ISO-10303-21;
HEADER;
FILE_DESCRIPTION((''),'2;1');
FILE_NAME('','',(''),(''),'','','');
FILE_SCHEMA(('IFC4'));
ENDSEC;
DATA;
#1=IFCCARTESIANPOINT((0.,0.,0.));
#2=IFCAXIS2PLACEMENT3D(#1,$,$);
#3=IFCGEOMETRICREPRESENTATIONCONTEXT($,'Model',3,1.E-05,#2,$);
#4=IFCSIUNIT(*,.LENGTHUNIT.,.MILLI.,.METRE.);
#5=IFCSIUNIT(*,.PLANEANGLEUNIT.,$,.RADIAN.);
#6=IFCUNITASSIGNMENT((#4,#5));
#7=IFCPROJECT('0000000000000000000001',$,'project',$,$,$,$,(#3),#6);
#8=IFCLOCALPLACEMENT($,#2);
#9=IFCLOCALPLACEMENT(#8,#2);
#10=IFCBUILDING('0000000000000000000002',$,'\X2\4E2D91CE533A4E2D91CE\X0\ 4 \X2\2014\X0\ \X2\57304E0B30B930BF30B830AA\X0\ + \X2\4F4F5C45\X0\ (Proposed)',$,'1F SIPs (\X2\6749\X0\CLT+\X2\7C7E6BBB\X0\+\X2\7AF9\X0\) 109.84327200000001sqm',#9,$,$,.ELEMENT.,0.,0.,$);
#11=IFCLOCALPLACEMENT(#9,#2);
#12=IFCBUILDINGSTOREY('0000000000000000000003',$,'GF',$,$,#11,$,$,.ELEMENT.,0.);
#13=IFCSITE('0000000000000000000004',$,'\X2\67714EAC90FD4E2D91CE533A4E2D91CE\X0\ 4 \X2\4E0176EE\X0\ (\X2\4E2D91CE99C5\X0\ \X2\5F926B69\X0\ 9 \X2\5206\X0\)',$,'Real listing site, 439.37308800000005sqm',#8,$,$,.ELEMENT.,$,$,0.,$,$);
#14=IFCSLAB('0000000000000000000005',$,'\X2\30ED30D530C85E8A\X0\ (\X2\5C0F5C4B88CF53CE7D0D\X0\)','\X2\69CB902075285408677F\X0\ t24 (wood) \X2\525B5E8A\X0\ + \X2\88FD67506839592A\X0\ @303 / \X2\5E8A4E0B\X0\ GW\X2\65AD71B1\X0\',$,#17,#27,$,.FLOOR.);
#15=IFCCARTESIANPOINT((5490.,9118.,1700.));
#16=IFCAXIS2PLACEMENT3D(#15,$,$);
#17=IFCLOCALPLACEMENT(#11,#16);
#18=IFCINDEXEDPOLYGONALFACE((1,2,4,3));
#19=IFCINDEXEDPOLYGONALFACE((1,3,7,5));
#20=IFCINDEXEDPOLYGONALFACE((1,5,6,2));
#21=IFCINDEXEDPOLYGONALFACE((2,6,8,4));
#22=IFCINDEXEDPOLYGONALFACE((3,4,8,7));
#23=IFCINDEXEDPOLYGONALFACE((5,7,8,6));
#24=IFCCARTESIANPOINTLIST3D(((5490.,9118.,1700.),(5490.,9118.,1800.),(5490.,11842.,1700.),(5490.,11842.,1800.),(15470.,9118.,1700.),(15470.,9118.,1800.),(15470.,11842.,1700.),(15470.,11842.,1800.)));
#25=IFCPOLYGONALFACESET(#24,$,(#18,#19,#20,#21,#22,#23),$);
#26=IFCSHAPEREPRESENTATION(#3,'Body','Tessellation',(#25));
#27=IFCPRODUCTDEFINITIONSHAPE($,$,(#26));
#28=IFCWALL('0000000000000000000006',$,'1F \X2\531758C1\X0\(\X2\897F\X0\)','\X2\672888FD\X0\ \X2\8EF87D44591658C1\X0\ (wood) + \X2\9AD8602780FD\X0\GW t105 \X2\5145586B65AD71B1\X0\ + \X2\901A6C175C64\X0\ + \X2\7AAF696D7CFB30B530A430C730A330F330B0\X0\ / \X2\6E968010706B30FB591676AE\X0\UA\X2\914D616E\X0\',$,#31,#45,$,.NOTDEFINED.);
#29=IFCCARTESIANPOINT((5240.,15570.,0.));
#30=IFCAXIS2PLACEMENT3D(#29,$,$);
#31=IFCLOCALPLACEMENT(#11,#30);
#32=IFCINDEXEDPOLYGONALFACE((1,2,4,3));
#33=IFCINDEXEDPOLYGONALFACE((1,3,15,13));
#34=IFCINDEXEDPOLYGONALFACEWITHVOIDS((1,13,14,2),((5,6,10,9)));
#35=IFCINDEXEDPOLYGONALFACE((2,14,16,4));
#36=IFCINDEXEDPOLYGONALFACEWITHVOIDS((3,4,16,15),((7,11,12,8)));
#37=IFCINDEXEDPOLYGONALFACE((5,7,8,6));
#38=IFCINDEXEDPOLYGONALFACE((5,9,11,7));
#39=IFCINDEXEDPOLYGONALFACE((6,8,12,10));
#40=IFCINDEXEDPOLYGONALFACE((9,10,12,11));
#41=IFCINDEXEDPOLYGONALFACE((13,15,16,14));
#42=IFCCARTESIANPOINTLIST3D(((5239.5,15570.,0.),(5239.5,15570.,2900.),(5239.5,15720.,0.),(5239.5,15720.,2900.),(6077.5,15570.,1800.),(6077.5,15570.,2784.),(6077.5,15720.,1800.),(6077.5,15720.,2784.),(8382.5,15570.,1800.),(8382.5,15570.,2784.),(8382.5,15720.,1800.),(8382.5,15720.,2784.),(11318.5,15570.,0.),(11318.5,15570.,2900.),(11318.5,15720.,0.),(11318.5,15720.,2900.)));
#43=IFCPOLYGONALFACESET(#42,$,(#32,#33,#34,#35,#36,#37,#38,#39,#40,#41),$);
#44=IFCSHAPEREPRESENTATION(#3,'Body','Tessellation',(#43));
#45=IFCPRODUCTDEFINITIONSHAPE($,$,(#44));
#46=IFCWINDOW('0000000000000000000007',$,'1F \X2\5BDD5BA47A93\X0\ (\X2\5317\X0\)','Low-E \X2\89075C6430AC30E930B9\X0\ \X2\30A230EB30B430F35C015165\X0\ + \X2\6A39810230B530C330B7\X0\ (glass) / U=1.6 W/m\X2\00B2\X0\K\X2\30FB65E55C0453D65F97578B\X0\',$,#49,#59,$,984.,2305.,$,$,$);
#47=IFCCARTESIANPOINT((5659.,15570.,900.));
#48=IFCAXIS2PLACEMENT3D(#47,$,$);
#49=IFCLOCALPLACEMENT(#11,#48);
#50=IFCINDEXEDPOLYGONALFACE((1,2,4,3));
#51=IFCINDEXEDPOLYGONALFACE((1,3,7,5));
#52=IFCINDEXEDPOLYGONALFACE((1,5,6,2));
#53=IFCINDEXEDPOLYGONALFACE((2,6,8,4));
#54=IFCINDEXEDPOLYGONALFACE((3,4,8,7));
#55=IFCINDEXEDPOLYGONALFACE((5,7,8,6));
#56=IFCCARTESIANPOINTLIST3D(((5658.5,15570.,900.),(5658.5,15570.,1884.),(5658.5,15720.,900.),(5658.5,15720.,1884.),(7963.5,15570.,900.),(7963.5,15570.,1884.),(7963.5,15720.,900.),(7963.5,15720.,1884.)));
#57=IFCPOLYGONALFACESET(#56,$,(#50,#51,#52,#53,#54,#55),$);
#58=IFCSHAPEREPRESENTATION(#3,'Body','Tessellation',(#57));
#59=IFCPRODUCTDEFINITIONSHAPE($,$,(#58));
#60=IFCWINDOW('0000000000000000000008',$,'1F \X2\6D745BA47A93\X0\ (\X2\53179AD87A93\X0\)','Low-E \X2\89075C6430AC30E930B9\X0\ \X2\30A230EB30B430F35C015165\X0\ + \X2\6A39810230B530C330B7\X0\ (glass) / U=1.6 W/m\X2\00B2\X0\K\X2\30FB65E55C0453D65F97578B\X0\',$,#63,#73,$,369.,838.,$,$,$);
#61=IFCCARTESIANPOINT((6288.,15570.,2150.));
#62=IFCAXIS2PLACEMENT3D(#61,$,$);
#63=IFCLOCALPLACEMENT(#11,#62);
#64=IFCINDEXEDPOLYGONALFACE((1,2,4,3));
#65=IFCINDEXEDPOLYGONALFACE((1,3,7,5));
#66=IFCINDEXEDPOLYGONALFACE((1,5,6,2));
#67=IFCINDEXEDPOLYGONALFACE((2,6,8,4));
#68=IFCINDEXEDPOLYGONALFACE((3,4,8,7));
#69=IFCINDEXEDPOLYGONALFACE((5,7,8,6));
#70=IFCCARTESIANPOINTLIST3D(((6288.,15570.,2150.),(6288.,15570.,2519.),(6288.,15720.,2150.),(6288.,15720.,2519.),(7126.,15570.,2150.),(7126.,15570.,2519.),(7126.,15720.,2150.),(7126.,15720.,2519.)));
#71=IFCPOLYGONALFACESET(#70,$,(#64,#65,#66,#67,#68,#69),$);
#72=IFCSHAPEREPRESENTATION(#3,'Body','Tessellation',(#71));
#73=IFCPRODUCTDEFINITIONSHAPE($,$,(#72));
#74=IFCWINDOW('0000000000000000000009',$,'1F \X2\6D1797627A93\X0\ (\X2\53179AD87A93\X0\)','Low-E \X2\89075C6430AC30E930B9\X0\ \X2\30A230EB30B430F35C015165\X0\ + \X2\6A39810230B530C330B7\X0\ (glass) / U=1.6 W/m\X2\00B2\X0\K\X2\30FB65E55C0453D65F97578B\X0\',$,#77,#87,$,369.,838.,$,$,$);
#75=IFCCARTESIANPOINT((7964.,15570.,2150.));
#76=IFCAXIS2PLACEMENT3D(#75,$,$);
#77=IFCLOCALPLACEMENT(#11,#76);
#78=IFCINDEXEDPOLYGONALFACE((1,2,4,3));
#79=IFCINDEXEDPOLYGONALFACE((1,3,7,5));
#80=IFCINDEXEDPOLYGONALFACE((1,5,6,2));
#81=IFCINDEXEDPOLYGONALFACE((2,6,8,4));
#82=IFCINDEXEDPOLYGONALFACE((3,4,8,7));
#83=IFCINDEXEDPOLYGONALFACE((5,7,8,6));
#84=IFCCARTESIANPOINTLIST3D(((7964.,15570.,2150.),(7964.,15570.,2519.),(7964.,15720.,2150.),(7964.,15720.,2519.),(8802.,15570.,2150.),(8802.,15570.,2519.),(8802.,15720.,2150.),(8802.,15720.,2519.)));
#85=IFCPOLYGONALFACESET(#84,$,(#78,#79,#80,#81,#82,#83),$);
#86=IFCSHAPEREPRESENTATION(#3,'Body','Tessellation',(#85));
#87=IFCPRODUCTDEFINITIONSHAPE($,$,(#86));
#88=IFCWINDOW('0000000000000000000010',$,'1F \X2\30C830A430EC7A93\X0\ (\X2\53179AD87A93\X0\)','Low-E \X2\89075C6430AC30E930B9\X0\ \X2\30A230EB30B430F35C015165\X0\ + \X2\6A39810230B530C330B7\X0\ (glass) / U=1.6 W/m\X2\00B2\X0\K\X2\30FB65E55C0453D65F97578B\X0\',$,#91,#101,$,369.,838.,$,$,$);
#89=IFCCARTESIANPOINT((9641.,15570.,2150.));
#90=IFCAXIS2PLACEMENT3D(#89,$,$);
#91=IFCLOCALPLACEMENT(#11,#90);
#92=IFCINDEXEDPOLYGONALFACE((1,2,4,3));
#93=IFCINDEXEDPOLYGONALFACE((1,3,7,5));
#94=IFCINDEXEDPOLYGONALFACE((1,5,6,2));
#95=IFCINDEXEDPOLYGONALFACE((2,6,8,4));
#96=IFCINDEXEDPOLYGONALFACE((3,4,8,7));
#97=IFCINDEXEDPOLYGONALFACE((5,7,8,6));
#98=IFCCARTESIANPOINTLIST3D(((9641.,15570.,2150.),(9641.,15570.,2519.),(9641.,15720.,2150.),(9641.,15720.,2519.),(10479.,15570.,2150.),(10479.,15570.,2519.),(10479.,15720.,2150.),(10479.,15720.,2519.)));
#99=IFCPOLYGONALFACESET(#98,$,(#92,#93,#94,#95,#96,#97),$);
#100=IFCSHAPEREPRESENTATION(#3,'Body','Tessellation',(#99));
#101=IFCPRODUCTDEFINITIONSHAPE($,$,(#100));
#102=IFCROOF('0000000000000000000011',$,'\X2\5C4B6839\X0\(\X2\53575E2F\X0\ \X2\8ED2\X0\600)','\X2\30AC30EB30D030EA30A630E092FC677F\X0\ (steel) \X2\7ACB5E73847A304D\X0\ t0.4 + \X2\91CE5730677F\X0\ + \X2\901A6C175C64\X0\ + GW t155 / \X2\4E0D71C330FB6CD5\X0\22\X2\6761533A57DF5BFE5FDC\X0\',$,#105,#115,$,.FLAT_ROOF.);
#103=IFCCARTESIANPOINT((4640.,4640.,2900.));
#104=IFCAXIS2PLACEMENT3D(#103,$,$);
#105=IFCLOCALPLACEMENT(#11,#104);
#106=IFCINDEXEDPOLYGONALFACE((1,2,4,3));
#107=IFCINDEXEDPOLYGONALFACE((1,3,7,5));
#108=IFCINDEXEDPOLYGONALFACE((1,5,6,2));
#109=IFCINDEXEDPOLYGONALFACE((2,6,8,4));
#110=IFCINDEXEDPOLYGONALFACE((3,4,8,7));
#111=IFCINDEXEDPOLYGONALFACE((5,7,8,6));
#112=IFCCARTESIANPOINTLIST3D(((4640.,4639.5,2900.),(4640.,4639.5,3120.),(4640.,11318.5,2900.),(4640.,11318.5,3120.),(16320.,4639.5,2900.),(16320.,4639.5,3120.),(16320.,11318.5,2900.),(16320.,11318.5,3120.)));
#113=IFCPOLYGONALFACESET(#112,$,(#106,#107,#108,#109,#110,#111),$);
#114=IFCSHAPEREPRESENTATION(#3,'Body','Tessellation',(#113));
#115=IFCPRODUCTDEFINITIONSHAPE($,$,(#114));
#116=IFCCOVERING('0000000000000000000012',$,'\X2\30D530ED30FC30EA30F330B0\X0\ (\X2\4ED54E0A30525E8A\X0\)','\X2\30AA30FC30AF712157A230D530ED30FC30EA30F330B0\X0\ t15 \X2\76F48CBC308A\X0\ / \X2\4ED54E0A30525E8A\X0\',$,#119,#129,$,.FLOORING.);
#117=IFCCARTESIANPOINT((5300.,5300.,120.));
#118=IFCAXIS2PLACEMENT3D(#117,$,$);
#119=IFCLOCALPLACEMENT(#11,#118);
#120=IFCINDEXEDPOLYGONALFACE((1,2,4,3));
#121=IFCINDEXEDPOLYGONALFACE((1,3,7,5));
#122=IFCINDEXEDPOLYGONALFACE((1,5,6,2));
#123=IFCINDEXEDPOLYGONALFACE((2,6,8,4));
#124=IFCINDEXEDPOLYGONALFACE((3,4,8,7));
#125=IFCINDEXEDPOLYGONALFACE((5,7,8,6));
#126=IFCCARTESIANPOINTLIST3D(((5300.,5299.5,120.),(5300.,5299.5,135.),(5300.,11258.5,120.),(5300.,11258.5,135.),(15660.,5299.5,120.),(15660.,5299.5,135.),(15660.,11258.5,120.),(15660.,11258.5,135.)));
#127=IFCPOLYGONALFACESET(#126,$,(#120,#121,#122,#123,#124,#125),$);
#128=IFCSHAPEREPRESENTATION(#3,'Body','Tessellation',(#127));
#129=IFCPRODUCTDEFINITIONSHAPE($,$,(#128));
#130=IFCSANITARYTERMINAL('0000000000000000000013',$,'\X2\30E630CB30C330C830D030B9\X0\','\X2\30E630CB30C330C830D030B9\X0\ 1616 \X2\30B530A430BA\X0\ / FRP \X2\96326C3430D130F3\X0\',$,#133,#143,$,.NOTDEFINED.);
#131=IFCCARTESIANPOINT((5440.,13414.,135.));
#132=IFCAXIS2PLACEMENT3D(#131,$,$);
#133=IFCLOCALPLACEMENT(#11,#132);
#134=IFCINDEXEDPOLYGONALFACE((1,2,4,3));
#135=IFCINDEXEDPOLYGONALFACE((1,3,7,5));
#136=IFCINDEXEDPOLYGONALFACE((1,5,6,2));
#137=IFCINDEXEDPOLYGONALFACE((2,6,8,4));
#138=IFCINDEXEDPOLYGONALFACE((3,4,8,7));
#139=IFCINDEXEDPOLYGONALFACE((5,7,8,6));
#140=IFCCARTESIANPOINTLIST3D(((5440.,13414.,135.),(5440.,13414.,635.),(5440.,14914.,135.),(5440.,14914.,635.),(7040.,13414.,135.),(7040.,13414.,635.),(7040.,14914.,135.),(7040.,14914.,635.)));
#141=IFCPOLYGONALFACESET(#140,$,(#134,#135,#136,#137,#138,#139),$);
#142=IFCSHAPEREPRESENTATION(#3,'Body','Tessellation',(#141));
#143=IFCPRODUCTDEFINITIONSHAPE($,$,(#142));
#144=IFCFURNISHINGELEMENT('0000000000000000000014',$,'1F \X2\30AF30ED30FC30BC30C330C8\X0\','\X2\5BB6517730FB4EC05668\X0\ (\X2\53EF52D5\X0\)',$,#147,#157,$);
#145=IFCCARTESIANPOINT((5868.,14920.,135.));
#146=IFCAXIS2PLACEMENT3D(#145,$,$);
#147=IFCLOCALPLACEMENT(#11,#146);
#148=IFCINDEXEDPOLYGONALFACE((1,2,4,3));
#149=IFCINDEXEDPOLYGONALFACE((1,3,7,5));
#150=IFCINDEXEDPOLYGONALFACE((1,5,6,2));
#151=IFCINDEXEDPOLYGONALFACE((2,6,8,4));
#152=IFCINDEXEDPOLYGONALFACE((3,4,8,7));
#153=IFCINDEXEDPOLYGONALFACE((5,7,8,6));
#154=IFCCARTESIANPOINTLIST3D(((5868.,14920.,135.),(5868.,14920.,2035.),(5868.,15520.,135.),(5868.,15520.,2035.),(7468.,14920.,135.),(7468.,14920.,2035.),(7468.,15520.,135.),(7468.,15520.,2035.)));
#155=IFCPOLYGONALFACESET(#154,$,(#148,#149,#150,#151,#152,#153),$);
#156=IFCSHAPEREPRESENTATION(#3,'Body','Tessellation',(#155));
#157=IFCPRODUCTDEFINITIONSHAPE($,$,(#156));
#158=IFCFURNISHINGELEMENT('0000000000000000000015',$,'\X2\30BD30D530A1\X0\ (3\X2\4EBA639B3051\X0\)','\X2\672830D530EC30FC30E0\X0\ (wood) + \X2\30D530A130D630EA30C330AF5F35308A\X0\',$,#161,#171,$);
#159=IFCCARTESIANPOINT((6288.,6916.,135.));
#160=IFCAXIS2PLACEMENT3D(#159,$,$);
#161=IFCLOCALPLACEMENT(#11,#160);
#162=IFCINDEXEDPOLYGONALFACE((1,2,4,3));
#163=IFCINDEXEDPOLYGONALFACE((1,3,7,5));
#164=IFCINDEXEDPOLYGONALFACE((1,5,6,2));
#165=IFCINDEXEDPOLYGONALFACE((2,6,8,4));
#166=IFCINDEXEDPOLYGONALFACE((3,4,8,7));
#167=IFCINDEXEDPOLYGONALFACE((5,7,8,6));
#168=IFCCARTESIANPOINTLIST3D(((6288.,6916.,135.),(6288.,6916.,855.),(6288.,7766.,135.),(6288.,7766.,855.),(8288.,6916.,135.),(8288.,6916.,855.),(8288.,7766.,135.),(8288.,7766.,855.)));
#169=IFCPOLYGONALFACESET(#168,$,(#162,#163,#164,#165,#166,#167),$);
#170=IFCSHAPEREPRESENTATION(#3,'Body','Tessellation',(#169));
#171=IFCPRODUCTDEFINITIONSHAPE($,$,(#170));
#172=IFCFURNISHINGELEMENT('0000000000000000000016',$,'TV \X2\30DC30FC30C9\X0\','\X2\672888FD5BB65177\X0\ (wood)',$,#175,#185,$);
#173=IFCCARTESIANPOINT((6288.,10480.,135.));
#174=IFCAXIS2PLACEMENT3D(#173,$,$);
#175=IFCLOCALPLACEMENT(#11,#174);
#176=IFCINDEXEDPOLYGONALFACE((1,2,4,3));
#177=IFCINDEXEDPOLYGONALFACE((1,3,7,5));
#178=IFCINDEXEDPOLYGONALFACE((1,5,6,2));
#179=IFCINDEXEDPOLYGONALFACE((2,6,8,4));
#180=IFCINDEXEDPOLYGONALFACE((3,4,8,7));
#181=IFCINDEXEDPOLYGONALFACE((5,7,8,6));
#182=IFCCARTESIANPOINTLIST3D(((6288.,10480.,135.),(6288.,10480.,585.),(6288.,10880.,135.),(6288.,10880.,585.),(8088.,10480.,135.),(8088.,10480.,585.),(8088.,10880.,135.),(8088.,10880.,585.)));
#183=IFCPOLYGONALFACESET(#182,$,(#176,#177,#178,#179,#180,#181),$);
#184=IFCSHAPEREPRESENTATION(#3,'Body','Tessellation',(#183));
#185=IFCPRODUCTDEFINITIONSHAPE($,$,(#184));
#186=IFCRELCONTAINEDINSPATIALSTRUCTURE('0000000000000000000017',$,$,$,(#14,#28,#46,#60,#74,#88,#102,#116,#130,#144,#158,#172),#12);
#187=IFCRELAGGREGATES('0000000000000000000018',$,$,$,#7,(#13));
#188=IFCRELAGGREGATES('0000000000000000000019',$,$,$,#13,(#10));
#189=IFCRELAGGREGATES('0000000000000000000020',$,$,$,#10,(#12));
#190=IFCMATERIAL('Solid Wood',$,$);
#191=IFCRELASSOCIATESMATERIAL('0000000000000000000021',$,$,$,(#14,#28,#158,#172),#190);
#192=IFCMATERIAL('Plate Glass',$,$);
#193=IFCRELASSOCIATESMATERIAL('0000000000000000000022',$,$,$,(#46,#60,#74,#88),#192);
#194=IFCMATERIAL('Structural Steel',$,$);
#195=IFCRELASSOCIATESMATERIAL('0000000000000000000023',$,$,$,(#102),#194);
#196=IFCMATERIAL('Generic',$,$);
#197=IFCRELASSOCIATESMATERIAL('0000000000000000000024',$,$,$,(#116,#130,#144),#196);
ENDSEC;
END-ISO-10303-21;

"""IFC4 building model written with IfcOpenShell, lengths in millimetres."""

from ifc_helpers import new_model, si_unit, frame, frame_2d, origin, place, context, project, spatial, rectangle, extrude, material, element, fill, save


model = new_model("IFC4")

# Units and contexts
model_context = context("Model", 3, precision=1e-05, world=origin())
ifc_project = project(units=[si_unit("LENGTHUNIT", "METRE", prefix="MILLI"), si_unit("PLANEANGLEUNIT", "RADIAN")], contexts=[model_context])

# Site, building, storey
site_placement = place(None, origin())
site = spatial("IfcSite", under=ifc_project, at=site_placement, Name="東京都中野区中野 4 丁目 (中野駅 徒歩 9 分)", ObjectType="Real listing site, 439.37308800000005sqm", CompositionType="ELEMENT", RefElevation=0.0)
building_placement = place(site_placement, origin())
building = spatial("IfcBuilding", under=site, at=building_placement, Name="中野区中野 4 — 地下スタジオ + 住居 (Proposed)", ObjectType="1F SIPs (杉CLT+籾殻+竹) 109.84327200000001sqm", CompositionType="ELEMENT", ElevationOfRefHeight=0.0, ElevationOfTerrain=0.0)
storey_placement = place(building_placement, origin())
storey = spatial("IfcBuildingStorey", under=building, at=storey_placement, Name="GF", CompositionType="ELEMENT", Elevation=0.0)

# Slab
ifc_material_1 = material(Name="Solid Wood")
slab_1_placement = place(storey_placement, frame((5490.0, 9118.0, 1700.0)))
element("IfcSlab", 1, at=slab_1_placement, inside=storey, material=ifc_material_1, Name="ロフト床 (小屋裏収納)", Description="構造用合板 t24 (wood) 剛床 + 製材根太 @303 / 床下 GW断熱", PredefinedType="FLOOR", context=model_context, shape_type="SweptSolid", body=[
    extrude(rectangle(XDim=9980.0, YDim=2724.0, at=frame_2d((4990.0, 1362.0))), frame((5490.0, 9118.0, 1700.0)), (0.0, 0.0, 1.0), 100.0),
])

# Shared definitions
ifc_material_2 = material(Name="Plate Glass")

# Wall, openings, windows
wall_1_placement = place(storey_placement, frame((5240.0, 15570.0, 0.0)))
wall_1 = element("IfcWall", 2, at=wall_1_placement, inside=storey, material=ifc_material_1, Name="1F 北壁(西)", Description="木製 軸組外壁 (wood) + 高性能GW t105 充填断熱 + 通気層 + 窯業系サイディング / 準耐火・外皮UA配慮", PredefinedType="NOTDEFINED", context=model_context, shape_type="SweptSolid", body=[
    extrude(rectangle(XDim=6079.0, YDim=150.0, at=frame_2d((3039.0, 75.0))), frame((5240.0, 15570.0, 0.0)), (0.0, 0.0, 1.0), 2900.0),
])
opening_1_placement = place(storey_placement, frame((5659.0, 15570.0, 900.0)))
opening_1 = element("IfcOpeningElement", 3, at=opening_1_placement, cuts=wall_1, PredefinedType="NOTDEFINED", context=model_context, shape_type="SweptSolid", body=[
    extrude(rectangle(XDim=2305.0, YDim=150.0, at=frame_2d((1152.0, 75.0))), frame((5659.0, 15570.0, 900.0)), (0.0, 0.0, 1.0), 984.0),
])
opening_2_placement = place(storey_placement, frame((6288.0, 15570.0, 2150.0)))
opening_2 = element("IfcOpeningElement", 4, at=opening_2_placement, cuts=wall_1, PredefinedType="NOTDEFINED", context=model_context, shape_type="SweptSolid", body=[
    extrude(rectangle(XDim=838.0, YDim=150.0, at=frame_2d((419.0, 75.0))), frame((6288.0, 15570.0, 2150.0)), (0.0, 0.0, 1.0), 369.0),
])
opening_3_placement = place(storey_placement, frame((7964.0, 15570.0, 2150.0)))
opening_3 = element("IfcOpeningElement", 5, at=opening_3_placement, cuts=wall_1, PredefinedType="NOTDEFINED", context=model_context, shape_type="SweptSolid", body=[
    extrude(rectangle(XDim=838.0, YDim=150.0, at=frame_2d((419.0, 75.0))), frame((7964.0, 15570.0, 2150.0)), (0.0, 0.0, 1.0), 369.0),
])
opening_4_placement = place(storey_placement, frame((9641.0, 15570.0, 2150.0)))
opening_4 = element("IfcOpeningElement", 6, at=opening_4_placement, cuts=wall_1, PredefinedType="NOTDEFINED", context=model_context, shape_type="SweptSolid", body=[
    extrude(rectangle(XDim=838.0, YDim=150.0, at=frame_2d((419.0, 75.0))), frame((9641.0, 15570.0, 2150.0)), (0.0, 0.0, 1.0), 369.0),
])
window_1_placement = place(storey_placement, frame((5659.0, 15570.0, 900.0)))
window_1 = element("IfcWindow", 7, at=window_1_placement, inside=storey, material=ifc_material_2, Name="1F 寝室窓 (北)", Description="Low-E 複層ガラス アルゴン封入 + 樹脂サッシ (glass) / U=1.6 W/m²K・日射取得型", OverallHeight=984.0, OverallWidth=2305.0, context=model_context, shape_type="SweptSolid", body=[
    extrude(rectangle(XDim=2305.0, YDim=150.0, at=frame_2d((1152.0, 75.0))), frame((5659.0, 15570.0, 900.0)), (0.0, 0.0, 1.0), 984.0),
])
fill(opening_1, window_1)
window_2_placement = place(storey_placement, frame((6288.0, 15570.0, 2150.0)))
window_2 = element("IfcWindow", 8, at=window_2_placement, inside=storey, material=ifc_material_2, Name="1F 浴室窓 (北高窓)", Description="Low-E 複層ガラス アルゴン封入 + 樹脂サッシ (glass) / U=1.6 W/m²K・日射取得型", OverallHeight=369.0, OverallWidth=838.0, context=model_context, shape_type="SweptSolid", body=[
    extrude(rectangle(XDim=838.0, YDim=150.0, at=frame_2d((419.0, 75.0))), frame((6288.0, 15570.0, 2150.0)), (0.0, 0.0, 1.0), 369.0),
])
fill(opening_2, window_2)
window_3_placement = place(storey_placement, frame((7964.0, 15570.0, 2150.0)))
window_3 = element("IfcWindow", 9, at=window_3_placement, inside=storey, material=ifc_material_2, Name="1F 洗面窓 (北高窓)", Description="Low-E 複層ガラス アルゴン封入 + 樹脂サッシ (glass) / U=1.6 W/m²K・日射取得型", OverallHeight=369.0, OverallWidth=838.0, context=model_context, shape_type="SweptSolid", body=[
    extrude(rectangle(XDim=838.0, YDim=150.0, at=frame_2d((419.0, 75.0))), frame((7964.0, 15570.0, 2150.0)), (0.0, 0.0, 1.0), 369.0),
])
fill(opening_3, window_3)
window_4_placement = place(storey_placement, frame((9641.0, 15570.0, 2150.0)))
window_4 = element("IfcWindow", 10, at=window_4_placement, inside=storey, material=ifc_material_2, Name="1F トイレ窓 (北高窓)", Description="Low-E 複層ガラス アルゴン封入 + 樹脂サッシ (glass) / U=1.6 W/m²K・日射取得型", OverallHeight=369.0, OverallWidth=838.0, context=model_context, shape_type="SweptSolid", body=[
    extrude(rectangle(XDim=838.0, YDim=150.0, at=frame_2d((419.0, 75.0))), frame((9641.0, 15570.0, 2150.0)), (0.0, 0.0, 1.0), 369.0),
])
fill(opening_4, window_4)

# Roof
ifc_material_3 = material(Name="Structural Steel")
roof_1_placement = place(storey_placement, frame((4640.0, 4640.0, 2900.0)))
element("IfcRoof", 11, at=roof_1_placement, inside=storey, material=ifc_material_3, Name="屋根(南帯 軒600)", Description="ガルバリウム鋼板 (steel) 立平葺き t0.4 + 野地板 + 通気層 + GW t155 / 不燃・法22条区域対応", PredefinedType="FLAT_ROOF", context=model_context, shape_type="SweptSolid", body=[
    extrude(rectangle(XDim=11680.0, YDim=6679.0, at=frame_2d((5840.0, 3339.0))), frame((4640.0, 4640.0, 2900.0)), (0.0, 0.0, 1.0), 220.0),
])

# Covering
ifc_material_4 = material(Name="Generic")
covering_1_placement = place(storey_placement, frame((5300.0, 5300.0, 120.0)))
element("IfcCovering", 12, at=covering_1_placement, inside=storey, material=ifc_material_4, Name="フローリング (仕上げ床)", Description="オーク無垢フローリング t15 直貼り / 仕上げ床", PredefinedType="FLOORING", context=model_context, shape_type="SweptSolid", body=[
    extrude(rectangle(XDim=10360.0, YDim=5959.0, at=frame_2d((5180.0, 2979.0))), frame((5300.0, 5300.0, 120.0)), (0.0, 0.0, 1.0), 15.0),
])

# Sanitary terminal
sanitary_terminal_placement = place(storey_placement, frame((5440.0, 13414.0, 135.0)))
element("IfcSanitaryTerminal", 13, at=sanitary_terminal_placement, inside=storey, material=ifc_material_4, Name="ユニットバス", Description="ユニットバス 1616 サイズ / FRP 防水パン", PredefinedType="NOTDEFINED", context=model_context, shape_type="SweptSolid", body=[
    extrude(rectangle(XDim=1600.0, YDim=1500.0, at=frame_2d((800.0, 750.0))), frame((5440.0, 13414.0, 135.0)), (0.0, 0.0, 1.0), 500.0),
])

# Furnishing elements
furnishing_1_placement = place(storey_placement, frame((5868.0, 14920.0, 135.0)))
element("IfcFurnishingElement", 14, at=furnishing_1_placement, inside=storey, material=ifc_material_4, Name="1F クローゼット", Description="家具・什器 (可動)", context=model_context, shape_type="SweptSolid", body=[
    extrude(rectangle(XDim=1600.0, YDim=600.0, at=frame_2d((800.0, 300.0))), frame((5868.0, 14920.0, 135.0)), (0.0, 0.0, 1.0), 1900.0),
])
furnishing_2_placement = place(storey_placement, frame((6288.0, 6916.0, 135.0)))
element("IfcFurnishingElement", 15, at=furnishing_2_placement, inside=storey, material=ifc_material_1, Name="ソファ (3人掛け)", Description="木フレーム (wood) + ファブリック張り", context=model_context, shape_type="SweptSolid", body=[
    extrude(rectangle(XDim=2000.0, YDim=850.0, at=frame_2d((1000.0, 425.0))), frame((6288.0, 6916.0, 135.0)), (0.0, 0.0, 1.0), 720.0),
])
furnishing_3_placement = place(storey_placement, frame((6288.0, 10480.0, 135.0)))
element("IfcFurnishingElement", 16, at=furnishing_3_placement, inside=storey, material=ifc_material_1, Name="TV ボード", Description="木製家具 (wood)", context=model_context, shape_type="SweptSolid", body=[
    extrude(rectangle(XDim=1800.0, YDim=400.0, at=frame_2d((900.0, 200.0))), frame((6288.0, 10480.0, 135.0)), (0.0, 0.0, 1.0), 450.0),
])

save(model, "model.ifc")
